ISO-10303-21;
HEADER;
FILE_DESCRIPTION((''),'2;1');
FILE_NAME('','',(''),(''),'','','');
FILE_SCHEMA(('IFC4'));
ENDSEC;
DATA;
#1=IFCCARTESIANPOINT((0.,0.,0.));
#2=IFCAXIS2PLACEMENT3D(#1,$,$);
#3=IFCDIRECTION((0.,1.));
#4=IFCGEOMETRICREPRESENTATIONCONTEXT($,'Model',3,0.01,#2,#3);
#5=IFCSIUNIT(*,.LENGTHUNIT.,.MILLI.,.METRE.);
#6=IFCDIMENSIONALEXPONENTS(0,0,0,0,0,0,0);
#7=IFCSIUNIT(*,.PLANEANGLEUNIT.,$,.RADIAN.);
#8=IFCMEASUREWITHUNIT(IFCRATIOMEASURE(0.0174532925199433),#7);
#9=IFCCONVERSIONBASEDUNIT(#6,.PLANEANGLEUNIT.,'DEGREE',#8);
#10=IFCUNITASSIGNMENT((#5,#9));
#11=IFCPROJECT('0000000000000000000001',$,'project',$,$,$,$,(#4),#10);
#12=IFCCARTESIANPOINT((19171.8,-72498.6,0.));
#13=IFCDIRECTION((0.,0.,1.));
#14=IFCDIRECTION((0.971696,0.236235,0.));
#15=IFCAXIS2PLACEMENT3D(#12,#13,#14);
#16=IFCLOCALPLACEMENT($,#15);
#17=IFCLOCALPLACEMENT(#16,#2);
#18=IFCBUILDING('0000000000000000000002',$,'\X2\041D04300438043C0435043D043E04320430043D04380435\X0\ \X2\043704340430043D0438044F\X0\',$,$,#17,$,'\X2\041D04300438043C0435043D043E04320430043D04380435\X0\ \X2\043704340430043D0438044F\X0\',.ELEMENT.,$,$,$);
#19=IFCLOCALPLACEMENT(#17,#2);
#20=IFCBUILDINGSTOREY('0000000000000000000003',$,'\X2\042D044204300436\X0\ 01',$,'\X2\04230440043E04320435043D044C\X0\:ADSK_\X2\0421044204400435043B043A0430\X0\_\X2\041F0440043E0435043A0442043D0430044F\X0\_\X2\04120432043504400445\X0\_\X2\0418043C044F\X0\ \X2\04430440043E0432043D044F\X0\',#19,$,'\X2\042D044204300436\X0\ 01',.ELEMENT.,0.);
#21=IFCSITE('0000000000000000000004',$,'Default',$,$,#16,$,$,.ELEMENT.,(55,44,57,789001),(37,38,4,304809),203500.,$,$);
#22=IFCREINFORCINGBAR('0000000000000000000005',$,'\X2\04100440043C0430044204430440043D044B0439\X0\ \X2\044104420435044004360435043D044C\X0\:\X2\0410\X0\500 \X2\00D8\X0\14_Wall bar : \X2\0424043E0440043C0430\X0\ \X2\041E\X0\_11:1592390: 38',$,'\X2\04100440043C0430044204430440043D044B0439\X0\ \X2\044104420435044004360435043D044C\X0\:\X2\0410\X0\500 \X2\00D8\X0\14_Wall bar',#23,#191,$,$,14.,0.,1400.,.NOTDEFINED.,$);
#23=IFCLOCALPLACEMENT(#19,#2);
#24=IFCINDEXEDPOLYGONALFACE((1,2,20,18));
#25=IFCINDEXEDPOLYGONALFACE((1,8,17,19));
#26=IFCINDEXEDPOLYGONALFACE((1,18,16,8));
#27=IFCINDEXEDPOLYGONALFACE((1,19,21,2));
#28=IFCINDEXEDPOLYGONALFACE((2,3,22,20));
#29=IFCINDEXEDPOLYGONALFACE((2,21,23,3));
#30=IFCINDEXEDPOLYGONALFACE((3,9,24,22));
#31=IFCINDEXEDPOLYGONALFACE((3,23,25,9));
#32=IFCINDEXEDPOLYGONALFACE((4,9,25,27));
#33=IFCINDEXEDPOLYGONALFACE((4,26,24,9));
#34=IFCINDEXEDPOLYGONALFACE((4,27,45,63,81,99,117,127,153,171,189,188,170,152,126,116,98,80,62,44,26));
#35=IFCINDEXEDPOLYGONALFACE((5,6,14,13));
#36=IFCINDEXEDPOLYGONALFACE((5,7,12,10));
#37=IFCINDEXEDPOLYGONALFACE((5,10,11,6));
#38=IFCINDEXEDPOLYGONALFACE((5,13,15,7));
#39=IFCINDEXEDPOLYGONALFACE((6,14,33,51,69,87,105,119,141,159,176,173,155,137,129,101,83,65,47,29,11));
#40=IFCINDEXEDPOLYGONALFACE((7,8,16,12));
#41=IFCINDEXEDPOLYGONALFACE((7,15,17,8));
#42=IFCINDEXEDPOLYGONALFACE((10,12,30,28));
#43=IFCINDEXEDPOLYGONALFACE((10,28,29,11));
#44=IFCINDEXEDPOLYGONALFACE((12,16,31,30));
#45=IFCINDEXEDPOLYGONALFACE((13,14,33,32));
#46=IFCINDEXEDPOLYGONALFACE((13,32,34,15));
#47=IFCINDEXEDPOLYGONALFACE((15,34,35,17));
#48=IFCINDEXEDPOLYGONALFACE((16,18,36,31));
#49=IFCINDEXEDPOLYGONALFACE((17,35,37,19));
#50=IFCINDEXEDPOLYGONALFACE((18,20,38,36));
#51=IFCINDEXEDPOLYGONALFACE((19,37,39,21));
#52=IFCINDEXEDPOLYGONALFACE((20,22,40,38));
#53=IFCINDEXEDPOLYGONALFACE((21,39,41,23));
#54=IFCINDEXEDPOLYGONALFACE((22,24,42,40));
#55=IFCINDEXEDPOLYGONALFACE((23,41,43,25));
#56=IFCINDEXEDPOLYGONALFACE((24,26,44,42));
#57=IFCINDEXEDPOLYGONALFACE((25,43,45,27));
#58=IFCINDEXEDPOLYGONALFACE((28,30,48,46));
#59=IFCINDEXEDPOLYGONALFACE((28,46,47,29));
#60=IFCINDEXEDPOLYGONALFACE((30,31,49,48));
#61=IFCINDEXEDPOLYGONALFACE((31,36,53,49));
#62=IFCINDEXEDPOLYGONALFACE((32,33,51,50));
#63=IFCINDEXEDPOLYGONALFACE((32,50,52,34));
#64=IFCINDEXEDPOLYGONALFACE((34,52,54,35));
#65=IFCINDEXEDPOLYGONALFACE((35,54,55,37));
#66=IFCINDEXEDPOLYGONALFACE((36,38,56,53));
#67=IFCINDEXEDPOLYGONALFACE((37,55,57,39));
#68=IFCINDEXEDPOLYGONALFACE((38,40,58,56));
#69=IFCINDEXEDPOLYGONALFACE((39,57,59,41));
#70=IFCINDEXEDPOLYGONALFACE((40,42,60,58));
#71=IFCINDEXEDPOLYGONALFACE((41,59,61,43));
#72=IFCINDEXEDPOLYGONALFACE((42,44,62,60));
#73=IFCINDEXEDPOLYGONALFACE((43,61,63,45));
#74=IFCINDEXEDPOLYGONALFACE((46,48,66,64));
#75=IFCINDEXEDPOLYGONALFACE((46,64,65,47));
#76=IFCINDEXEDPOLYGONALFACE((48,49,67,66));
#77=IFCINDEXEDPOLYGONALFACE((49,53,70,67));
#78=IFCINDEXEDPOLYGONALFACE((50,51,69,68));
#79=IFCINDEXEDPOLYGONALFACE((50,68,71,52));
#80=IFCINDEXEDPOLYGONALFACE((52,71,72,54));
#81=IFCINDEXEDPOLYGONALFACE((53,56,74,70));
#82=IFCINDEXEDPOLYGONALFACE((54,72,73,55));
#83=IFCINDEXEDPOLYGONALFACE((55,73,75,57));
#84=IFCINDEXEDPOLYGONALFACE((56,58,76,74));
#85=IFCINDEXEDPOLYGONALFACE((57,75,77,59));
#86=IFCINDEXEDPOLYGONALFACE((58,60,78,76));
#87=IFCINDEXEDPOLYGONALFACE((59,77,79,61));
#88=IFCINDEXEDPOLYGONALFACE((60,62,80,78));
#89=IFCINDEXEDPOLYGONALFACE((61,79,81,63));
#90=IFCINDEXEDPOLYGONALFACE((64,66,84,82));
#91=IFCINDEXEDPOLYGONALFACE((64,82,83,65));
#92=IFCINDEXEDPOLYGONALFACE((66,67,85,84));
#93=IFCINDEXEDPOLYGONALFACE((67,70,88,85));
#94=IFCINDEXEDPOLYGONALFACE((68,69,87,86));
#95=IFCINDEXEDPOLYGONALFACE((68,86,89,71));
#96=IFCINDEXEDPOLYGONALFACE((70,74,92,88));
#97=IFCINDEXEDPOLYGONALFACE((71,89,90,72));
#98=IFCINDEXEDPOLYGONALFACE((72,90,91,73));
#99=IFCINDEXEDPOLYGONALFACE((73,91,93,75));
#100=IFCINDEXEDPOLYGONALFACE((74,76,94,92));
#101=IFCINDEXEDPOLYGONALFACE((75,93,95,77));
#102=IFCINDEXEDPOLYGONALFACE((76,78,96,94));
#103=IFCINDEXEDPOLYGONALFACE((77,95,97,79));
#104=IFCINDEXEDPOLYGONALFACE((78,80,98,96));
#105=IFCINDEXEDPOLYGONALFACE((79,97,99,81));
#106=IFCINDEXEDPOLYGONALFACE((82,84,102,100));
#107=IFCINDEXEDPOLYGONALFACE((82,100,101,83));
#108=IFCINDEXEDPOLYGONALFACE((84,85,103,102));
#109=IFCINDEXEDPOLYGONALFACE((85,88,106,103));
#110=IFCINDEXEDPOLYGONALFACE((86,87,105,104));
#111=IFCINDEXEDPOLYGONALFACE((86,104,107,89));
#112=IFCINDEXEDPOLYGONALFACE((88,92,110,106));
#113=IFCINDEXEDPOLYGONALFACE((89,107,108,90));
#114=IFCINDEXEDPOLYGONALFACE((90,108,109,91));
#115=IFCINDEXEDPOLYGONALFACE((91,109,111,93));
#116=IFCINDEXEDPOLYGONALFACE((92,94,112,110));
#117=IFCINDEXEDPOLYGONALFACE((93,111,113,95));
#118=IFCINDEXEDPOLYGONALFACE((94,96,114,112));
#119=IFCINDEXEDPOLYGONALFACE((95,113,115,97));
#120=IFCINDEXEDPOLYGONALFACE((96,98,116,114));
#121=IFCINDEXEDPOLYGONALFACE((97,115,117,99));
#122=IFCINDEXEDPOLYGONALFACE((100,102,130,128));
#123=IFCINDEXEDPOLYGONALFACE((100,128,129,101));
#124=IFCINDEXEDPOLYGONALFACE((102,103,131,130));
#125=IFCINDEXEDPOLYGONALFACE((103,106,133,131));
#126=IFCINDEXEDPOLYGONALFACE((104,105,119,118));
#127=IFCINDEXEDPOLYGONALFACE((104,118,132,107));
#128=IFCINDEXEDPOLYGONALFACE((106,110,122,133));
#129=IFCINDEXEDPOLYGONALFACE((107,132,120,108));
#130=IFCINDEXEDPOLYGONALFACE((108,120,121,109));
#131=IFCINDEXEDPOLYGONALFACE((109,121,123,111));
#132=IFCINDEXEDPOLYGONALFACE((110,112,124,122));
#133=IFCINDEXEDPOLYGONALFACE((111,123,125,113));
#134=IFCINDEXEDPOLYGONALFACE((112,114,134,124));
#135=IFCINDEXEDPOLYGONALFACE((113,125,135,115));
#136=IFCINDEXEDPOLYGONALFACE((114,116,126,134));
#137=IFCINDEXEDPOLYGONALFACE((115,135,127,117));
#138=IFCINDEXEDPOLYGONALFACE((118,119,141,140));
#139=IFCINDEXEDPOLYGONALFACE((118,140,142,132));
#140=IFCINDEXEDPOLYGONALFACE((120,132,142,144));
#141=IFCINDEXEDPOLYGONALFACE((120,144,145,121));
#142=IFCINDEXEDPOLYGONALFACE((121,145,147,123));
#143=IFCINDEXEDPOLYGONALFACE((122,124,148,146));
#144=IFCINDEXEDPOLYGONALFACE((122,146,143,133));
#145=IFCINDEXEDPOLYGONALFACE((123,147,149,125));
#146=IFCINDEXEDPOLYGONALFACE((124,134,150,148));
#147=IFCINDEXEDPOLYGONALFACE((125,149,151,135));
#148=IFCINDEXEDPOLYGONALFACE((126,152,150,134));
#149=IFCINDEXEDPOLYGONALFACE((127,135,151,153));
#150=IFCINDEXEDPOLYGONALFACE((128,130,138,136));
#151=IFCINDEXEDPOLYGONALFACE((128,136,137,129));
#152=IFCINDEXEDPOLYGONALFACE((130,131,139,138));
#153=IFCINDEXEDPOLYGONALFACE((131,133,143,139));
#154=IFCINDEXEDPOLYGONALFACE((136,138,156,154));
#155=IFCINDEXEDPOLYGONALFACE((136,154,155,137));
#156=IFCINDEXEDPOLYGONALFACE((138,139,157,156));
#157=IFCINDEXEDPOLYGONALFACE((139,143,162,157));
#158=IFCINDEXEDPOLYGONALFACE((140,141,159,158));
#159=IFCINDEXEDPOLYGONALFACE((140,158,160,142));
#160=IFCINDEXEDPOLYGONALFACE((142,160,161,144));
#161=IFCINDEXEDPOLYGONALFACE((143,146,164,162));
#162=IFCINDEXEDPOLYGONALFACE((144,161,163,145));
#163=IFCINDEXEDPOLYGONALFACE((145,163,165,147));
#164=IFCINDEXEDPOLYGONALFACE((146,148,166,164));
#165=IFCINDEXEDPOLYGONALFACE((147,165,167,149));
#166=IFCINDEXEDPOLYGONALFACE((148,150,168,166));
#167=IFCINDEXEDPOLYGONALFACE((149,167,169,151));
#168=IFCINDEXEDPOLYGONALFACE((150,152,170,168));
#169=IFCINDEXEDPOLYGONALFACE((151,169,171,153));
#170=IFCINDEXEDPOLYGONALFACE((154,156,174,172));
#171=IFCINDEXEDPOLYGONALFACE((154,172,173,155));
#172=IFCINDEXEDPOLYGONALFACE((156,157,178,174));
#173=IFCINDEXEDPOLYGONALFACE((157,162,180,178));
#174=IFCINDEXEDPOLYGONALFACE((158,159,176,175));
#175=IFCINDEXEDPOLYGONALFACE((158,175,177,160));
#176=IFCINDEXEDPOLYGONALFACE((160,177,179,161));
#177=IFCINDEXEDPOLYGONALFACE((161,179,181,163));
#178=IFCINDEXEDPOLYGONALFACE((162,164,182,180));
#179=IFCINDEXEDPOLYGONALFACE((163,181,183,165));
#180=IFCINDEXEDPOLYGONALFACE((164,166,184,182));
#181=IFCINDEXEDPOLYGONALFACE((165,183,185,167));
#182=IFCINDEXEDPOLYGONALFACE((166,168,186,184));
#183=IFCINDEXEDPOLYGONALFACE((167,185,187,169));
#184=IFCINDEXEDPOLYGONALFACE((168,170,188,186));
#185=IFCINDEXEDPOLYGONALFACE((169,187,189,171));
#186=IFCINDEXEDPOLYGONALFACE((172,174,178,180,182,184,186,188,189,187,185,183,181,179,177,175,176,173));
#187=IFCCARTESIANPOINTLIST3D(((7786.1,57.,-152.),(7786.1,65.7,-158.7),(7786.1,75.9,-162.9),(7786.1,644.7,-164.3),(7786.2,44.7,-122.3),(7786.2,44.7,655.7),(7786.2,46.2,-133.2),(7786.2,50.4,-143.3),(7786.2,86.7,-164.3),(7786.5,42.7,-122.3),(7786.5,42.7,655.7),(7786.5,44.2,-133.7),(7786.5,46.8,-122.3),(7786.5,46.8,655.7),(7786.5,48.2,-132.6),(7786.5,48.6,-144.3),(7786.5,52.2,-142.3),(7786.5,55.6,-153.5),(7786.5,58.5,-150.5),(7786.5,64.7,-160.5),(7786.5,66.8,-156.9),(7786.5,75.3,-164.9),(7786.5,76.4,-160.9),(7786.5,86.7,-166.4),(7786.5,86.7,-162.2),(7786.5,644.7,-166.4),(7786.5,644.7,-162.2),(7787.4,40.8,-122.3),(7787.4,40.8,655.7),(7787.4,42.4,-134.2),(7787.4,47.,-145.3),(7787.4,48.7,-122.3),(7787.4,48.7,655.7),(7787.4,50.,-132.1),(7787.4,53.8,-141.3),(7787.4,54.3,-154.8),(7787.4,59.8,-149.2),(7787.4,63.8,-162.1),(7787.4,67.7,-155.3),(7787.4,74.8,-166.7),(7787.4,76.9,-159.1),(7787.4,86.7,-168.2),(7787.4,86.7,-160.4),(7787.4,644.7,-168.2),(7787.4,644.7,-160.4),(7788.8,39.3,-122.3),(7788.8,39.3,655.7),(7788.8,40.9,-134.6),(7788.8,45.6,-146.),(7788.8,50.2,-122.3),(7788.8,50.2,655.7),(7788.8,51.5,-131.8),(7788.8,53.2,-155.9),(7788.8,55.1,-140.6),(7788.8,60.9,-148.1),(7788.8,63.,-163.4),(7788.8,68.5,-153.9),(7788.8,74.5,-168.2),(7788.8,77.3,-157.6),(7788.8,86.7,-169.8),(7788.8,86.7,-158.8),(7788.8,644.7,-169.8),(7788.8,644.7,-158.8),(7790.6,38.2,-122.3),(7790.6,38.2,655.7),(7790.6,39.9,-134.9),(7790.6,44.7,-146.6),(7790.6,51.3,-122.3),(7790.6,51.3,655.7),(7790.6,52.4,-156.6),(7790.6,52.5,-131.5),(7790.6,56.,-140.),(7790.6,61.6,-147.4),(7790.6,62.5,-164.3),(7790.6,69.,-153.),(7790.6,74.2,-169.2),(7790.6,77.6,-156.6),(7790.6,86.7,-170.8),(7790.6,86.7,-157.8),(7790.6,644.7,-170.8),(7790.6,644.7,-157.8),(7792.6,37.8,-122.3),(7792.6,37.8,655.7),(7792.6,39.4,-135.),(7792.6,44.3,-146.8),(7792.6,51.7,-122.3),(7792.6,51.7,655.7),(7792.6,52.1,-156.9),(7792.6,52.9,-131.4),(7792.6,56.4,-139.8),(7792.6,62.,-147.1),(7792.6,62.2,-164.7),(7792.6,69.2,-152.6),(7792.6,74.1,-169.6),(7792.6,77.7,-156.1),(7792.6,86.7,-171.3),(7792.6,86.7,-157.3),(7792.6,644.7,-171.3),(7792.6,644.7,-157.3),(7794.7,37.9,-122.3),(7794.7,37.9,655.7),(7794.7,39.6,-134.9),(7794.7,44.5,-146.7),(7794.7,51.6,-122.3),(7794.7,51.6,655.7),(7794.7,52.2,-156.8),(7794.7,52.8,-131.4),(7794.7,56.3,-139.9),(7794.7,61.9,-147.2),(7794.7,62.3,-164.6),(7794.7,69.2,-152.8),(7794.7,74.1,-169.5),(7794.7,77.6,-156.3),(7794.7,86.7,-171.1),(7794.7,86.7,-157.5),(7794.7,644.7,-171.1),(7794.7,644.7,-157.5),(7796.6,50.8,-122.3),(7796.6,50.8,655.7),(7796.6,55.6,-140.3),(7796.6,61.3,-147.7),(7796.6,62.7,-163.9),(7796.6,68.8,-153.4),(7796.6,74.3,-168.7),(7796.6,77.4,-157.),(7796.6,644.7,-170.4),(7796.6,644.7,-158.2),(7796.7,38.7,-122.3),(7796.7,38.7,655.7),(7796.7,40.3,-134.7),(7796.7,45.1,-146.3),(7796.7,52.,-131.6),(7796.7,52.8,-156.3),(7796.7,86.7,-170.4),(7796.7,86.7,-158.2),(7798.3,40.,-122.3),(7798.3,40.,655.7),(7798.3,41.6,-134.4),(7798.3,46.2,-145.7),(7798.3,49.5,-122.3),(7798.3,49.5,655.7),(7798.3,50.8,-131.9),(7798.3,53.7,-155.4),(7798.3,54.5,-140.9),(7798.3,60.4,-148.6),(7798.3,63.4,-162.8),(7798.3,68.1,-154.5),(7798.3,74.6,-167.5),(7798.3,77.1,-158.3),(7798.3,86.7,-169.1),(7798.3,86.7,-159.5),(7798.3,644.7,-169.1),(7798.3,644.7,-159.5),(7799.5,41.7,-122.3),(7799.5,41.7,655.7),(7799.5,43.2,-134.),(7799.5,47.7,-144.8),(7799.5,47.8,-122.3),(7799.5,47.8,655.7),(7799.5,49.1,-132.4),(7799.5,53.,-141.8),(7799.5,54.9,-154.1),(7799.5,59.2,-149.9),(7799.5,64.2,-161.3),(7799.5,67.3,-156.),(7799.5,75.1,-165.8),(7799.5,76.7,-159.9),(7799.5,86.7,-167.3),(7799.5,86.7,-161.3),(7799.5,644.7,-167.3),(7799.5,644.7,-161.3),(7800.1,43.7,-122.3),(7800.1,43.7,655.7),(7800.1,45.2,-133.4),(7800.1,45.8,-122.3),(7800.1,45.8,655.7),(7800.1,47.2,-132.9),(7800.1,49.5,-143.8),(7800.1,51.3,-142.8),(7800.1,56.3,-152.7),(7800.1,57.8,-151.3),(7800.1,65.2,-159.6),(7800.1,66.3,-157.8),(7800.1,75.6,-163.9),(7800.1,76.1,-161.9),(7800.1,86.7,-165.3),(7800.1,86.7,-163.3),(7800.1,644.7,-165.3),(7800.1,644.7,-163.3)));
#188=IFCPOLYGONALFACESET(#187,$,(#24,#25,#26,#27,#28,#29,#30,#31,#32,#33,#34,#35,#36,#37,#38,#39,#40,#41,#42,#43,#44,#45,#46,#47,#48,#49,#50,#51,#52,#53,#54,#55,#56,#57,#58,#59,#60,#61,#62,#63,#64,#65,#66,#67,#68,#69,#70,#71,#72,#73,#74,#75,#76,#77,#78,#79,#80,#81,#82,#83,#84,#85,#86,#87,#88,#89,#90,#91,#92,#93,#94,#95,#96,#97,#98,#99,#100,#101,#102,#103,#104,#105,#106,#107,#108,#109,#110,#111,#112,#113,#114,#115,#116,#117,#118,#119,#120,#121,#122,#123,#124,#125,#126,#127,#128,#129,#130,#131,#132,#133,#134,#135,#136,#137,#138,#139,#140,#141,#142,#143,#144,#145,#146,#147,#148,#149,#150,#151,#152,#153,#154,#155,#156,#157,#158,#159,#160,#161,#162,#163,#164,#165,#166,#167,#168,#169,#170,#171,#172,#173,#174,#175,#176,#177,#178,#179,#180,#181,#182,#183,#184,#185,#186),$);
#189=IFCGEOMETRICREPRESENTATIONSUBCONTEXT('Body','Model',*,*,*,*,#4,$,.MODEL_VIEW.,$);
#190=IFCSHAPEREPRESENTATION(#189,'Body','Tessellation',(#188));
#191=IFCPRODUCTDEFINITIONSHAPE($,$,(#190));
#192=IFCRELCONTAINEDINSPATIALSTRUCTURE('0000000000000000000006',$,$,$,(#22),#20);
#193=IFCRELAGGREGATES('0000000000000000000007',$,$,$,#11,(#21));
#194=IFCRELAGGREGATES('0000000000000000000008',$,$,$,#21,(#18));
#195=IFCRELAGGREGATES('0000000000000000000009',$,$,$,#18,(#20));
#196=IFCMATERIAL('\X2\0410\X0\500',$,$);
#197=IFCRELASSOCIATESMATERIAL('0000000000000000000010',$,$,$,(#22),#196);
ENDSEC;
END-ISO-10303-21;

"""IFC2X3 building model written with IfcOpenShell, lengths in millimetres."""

from ifc_helpers import new_model, entity, si_unit, converted_unit, direction, frame, origin, place, context, subcontext, project, spatial, material, element, save


model = new_model("IFC2X3")

# Units and contexts
model_context = context("Model", 3, precision=0.01, world=origin(), true_north=direction((0.0, 1.0)))
body_context = subcontext(model_context, "Body", "Model", "MODEL_VIEW")
ifc_project = project(units=[si_unit("LENGTHUNIT", "METRE", prefix="MILLI"), converted_unit("PLANEANGLEUNIT", "DEGREE", entity("IfcRatioMeasure", 0.0174532925199433), si_unit("PLANEANGLEUNIT", "RADIAN"), dimensions=[0, 0, 0, 0, 0, 0, 0])], contexts=[model_context])

# Site, building, storey
site_placement = place(None, frame((19171.8, -72498.6, 0.0), z_axis=(0.0, 0.0, 1.0), x_axis=(0.971696, 0.236235, 0.0)))
site = spatial("IfcSite", under=ifc_project, at=site_placement, Name="Default", CompositionType="ELEMENT", RefLatitude=(55, 44, 57, 789001), RefLongitude=(37, 38, 4, 304809), RefElevation=203500.0)
building_placement = place(site_placement, origin())
building = spatial("IfcBuilding", under=site, at=building_placement, Name="Наименование здания", LongName="Наименование здания", CompositionType="ELEMENT")
storey_placement = place(building_placement, origin())
storey = spatial("IfcBuildingStorey", under=building, at=storey_placement, Name="Этаж 01", ObjectType="Уровень:ADSK_Стрелка_Проектная_Вверх_Имя уровня", LongName="Этаж 01", CompositionType="ELEMENT", Elevation=0.0)

# Reinforcing bar
ifc_material = material(Name="А500")
placement = place(storey_placement, origin())
element("IfcReinforcingBar", 1, at=placement, inside=storey, material=ifc_material, Name="Арматурный стержень:А500 Ø14_Wall bar : Форма О_11:1592390: 38", ObjectType="Арматурный стержень:А500 Ø14_Wall bar", BarLength=1400.0, BarRole="NOTDEFINED", CrossSectionArea=0.0, NominalDiameter=14.0, context=body_context, shape_type="AdvancedSweptSolid", body=[
    entity("IfcSweptDiskSolid", entity("IfcCompositeCurve", [entity("IfcCompositeCurveSegment", "CONTINUOUS", True, entity("IfcPolyline", [entity("IfcCartesianPoint", [7793.1, 44.7, 655.7]), entity("IfcCartesianPoint", [7793.1, 44.7, -122.3])])), entity("IfcCompositeCurveSegment", "CONTINUOUS", True, entity("IfcTrimmedCurve", entity("IfcCircle", entity("IfcAxis2Placement3D", entity("IfcCartesianPoint", [7793.1, 86.7, -122.3]), entity("IfcDirection", [1.0, 0.0, 0.0]), entity("IfcDirection", [0.0, 0.0, -1.0])), 42.0), [entity("IfcParameterValue", 270.0)], [entity("IfcParameterValue", 360.0)], True, "PARAMETER")), entity("IfcCompositeCurveSegment", "CONTINUOUS", True, entity("IfcPolyline", [entity("IfcCartesianPoint", [7793.1, 86.7, -164.3]), entity("IfcCartesianPoint", [7793.1, 644.7, -164.3])]))], False), 7.0, None, 0.0, 92.0),
])

save(model, "model.ifc")
